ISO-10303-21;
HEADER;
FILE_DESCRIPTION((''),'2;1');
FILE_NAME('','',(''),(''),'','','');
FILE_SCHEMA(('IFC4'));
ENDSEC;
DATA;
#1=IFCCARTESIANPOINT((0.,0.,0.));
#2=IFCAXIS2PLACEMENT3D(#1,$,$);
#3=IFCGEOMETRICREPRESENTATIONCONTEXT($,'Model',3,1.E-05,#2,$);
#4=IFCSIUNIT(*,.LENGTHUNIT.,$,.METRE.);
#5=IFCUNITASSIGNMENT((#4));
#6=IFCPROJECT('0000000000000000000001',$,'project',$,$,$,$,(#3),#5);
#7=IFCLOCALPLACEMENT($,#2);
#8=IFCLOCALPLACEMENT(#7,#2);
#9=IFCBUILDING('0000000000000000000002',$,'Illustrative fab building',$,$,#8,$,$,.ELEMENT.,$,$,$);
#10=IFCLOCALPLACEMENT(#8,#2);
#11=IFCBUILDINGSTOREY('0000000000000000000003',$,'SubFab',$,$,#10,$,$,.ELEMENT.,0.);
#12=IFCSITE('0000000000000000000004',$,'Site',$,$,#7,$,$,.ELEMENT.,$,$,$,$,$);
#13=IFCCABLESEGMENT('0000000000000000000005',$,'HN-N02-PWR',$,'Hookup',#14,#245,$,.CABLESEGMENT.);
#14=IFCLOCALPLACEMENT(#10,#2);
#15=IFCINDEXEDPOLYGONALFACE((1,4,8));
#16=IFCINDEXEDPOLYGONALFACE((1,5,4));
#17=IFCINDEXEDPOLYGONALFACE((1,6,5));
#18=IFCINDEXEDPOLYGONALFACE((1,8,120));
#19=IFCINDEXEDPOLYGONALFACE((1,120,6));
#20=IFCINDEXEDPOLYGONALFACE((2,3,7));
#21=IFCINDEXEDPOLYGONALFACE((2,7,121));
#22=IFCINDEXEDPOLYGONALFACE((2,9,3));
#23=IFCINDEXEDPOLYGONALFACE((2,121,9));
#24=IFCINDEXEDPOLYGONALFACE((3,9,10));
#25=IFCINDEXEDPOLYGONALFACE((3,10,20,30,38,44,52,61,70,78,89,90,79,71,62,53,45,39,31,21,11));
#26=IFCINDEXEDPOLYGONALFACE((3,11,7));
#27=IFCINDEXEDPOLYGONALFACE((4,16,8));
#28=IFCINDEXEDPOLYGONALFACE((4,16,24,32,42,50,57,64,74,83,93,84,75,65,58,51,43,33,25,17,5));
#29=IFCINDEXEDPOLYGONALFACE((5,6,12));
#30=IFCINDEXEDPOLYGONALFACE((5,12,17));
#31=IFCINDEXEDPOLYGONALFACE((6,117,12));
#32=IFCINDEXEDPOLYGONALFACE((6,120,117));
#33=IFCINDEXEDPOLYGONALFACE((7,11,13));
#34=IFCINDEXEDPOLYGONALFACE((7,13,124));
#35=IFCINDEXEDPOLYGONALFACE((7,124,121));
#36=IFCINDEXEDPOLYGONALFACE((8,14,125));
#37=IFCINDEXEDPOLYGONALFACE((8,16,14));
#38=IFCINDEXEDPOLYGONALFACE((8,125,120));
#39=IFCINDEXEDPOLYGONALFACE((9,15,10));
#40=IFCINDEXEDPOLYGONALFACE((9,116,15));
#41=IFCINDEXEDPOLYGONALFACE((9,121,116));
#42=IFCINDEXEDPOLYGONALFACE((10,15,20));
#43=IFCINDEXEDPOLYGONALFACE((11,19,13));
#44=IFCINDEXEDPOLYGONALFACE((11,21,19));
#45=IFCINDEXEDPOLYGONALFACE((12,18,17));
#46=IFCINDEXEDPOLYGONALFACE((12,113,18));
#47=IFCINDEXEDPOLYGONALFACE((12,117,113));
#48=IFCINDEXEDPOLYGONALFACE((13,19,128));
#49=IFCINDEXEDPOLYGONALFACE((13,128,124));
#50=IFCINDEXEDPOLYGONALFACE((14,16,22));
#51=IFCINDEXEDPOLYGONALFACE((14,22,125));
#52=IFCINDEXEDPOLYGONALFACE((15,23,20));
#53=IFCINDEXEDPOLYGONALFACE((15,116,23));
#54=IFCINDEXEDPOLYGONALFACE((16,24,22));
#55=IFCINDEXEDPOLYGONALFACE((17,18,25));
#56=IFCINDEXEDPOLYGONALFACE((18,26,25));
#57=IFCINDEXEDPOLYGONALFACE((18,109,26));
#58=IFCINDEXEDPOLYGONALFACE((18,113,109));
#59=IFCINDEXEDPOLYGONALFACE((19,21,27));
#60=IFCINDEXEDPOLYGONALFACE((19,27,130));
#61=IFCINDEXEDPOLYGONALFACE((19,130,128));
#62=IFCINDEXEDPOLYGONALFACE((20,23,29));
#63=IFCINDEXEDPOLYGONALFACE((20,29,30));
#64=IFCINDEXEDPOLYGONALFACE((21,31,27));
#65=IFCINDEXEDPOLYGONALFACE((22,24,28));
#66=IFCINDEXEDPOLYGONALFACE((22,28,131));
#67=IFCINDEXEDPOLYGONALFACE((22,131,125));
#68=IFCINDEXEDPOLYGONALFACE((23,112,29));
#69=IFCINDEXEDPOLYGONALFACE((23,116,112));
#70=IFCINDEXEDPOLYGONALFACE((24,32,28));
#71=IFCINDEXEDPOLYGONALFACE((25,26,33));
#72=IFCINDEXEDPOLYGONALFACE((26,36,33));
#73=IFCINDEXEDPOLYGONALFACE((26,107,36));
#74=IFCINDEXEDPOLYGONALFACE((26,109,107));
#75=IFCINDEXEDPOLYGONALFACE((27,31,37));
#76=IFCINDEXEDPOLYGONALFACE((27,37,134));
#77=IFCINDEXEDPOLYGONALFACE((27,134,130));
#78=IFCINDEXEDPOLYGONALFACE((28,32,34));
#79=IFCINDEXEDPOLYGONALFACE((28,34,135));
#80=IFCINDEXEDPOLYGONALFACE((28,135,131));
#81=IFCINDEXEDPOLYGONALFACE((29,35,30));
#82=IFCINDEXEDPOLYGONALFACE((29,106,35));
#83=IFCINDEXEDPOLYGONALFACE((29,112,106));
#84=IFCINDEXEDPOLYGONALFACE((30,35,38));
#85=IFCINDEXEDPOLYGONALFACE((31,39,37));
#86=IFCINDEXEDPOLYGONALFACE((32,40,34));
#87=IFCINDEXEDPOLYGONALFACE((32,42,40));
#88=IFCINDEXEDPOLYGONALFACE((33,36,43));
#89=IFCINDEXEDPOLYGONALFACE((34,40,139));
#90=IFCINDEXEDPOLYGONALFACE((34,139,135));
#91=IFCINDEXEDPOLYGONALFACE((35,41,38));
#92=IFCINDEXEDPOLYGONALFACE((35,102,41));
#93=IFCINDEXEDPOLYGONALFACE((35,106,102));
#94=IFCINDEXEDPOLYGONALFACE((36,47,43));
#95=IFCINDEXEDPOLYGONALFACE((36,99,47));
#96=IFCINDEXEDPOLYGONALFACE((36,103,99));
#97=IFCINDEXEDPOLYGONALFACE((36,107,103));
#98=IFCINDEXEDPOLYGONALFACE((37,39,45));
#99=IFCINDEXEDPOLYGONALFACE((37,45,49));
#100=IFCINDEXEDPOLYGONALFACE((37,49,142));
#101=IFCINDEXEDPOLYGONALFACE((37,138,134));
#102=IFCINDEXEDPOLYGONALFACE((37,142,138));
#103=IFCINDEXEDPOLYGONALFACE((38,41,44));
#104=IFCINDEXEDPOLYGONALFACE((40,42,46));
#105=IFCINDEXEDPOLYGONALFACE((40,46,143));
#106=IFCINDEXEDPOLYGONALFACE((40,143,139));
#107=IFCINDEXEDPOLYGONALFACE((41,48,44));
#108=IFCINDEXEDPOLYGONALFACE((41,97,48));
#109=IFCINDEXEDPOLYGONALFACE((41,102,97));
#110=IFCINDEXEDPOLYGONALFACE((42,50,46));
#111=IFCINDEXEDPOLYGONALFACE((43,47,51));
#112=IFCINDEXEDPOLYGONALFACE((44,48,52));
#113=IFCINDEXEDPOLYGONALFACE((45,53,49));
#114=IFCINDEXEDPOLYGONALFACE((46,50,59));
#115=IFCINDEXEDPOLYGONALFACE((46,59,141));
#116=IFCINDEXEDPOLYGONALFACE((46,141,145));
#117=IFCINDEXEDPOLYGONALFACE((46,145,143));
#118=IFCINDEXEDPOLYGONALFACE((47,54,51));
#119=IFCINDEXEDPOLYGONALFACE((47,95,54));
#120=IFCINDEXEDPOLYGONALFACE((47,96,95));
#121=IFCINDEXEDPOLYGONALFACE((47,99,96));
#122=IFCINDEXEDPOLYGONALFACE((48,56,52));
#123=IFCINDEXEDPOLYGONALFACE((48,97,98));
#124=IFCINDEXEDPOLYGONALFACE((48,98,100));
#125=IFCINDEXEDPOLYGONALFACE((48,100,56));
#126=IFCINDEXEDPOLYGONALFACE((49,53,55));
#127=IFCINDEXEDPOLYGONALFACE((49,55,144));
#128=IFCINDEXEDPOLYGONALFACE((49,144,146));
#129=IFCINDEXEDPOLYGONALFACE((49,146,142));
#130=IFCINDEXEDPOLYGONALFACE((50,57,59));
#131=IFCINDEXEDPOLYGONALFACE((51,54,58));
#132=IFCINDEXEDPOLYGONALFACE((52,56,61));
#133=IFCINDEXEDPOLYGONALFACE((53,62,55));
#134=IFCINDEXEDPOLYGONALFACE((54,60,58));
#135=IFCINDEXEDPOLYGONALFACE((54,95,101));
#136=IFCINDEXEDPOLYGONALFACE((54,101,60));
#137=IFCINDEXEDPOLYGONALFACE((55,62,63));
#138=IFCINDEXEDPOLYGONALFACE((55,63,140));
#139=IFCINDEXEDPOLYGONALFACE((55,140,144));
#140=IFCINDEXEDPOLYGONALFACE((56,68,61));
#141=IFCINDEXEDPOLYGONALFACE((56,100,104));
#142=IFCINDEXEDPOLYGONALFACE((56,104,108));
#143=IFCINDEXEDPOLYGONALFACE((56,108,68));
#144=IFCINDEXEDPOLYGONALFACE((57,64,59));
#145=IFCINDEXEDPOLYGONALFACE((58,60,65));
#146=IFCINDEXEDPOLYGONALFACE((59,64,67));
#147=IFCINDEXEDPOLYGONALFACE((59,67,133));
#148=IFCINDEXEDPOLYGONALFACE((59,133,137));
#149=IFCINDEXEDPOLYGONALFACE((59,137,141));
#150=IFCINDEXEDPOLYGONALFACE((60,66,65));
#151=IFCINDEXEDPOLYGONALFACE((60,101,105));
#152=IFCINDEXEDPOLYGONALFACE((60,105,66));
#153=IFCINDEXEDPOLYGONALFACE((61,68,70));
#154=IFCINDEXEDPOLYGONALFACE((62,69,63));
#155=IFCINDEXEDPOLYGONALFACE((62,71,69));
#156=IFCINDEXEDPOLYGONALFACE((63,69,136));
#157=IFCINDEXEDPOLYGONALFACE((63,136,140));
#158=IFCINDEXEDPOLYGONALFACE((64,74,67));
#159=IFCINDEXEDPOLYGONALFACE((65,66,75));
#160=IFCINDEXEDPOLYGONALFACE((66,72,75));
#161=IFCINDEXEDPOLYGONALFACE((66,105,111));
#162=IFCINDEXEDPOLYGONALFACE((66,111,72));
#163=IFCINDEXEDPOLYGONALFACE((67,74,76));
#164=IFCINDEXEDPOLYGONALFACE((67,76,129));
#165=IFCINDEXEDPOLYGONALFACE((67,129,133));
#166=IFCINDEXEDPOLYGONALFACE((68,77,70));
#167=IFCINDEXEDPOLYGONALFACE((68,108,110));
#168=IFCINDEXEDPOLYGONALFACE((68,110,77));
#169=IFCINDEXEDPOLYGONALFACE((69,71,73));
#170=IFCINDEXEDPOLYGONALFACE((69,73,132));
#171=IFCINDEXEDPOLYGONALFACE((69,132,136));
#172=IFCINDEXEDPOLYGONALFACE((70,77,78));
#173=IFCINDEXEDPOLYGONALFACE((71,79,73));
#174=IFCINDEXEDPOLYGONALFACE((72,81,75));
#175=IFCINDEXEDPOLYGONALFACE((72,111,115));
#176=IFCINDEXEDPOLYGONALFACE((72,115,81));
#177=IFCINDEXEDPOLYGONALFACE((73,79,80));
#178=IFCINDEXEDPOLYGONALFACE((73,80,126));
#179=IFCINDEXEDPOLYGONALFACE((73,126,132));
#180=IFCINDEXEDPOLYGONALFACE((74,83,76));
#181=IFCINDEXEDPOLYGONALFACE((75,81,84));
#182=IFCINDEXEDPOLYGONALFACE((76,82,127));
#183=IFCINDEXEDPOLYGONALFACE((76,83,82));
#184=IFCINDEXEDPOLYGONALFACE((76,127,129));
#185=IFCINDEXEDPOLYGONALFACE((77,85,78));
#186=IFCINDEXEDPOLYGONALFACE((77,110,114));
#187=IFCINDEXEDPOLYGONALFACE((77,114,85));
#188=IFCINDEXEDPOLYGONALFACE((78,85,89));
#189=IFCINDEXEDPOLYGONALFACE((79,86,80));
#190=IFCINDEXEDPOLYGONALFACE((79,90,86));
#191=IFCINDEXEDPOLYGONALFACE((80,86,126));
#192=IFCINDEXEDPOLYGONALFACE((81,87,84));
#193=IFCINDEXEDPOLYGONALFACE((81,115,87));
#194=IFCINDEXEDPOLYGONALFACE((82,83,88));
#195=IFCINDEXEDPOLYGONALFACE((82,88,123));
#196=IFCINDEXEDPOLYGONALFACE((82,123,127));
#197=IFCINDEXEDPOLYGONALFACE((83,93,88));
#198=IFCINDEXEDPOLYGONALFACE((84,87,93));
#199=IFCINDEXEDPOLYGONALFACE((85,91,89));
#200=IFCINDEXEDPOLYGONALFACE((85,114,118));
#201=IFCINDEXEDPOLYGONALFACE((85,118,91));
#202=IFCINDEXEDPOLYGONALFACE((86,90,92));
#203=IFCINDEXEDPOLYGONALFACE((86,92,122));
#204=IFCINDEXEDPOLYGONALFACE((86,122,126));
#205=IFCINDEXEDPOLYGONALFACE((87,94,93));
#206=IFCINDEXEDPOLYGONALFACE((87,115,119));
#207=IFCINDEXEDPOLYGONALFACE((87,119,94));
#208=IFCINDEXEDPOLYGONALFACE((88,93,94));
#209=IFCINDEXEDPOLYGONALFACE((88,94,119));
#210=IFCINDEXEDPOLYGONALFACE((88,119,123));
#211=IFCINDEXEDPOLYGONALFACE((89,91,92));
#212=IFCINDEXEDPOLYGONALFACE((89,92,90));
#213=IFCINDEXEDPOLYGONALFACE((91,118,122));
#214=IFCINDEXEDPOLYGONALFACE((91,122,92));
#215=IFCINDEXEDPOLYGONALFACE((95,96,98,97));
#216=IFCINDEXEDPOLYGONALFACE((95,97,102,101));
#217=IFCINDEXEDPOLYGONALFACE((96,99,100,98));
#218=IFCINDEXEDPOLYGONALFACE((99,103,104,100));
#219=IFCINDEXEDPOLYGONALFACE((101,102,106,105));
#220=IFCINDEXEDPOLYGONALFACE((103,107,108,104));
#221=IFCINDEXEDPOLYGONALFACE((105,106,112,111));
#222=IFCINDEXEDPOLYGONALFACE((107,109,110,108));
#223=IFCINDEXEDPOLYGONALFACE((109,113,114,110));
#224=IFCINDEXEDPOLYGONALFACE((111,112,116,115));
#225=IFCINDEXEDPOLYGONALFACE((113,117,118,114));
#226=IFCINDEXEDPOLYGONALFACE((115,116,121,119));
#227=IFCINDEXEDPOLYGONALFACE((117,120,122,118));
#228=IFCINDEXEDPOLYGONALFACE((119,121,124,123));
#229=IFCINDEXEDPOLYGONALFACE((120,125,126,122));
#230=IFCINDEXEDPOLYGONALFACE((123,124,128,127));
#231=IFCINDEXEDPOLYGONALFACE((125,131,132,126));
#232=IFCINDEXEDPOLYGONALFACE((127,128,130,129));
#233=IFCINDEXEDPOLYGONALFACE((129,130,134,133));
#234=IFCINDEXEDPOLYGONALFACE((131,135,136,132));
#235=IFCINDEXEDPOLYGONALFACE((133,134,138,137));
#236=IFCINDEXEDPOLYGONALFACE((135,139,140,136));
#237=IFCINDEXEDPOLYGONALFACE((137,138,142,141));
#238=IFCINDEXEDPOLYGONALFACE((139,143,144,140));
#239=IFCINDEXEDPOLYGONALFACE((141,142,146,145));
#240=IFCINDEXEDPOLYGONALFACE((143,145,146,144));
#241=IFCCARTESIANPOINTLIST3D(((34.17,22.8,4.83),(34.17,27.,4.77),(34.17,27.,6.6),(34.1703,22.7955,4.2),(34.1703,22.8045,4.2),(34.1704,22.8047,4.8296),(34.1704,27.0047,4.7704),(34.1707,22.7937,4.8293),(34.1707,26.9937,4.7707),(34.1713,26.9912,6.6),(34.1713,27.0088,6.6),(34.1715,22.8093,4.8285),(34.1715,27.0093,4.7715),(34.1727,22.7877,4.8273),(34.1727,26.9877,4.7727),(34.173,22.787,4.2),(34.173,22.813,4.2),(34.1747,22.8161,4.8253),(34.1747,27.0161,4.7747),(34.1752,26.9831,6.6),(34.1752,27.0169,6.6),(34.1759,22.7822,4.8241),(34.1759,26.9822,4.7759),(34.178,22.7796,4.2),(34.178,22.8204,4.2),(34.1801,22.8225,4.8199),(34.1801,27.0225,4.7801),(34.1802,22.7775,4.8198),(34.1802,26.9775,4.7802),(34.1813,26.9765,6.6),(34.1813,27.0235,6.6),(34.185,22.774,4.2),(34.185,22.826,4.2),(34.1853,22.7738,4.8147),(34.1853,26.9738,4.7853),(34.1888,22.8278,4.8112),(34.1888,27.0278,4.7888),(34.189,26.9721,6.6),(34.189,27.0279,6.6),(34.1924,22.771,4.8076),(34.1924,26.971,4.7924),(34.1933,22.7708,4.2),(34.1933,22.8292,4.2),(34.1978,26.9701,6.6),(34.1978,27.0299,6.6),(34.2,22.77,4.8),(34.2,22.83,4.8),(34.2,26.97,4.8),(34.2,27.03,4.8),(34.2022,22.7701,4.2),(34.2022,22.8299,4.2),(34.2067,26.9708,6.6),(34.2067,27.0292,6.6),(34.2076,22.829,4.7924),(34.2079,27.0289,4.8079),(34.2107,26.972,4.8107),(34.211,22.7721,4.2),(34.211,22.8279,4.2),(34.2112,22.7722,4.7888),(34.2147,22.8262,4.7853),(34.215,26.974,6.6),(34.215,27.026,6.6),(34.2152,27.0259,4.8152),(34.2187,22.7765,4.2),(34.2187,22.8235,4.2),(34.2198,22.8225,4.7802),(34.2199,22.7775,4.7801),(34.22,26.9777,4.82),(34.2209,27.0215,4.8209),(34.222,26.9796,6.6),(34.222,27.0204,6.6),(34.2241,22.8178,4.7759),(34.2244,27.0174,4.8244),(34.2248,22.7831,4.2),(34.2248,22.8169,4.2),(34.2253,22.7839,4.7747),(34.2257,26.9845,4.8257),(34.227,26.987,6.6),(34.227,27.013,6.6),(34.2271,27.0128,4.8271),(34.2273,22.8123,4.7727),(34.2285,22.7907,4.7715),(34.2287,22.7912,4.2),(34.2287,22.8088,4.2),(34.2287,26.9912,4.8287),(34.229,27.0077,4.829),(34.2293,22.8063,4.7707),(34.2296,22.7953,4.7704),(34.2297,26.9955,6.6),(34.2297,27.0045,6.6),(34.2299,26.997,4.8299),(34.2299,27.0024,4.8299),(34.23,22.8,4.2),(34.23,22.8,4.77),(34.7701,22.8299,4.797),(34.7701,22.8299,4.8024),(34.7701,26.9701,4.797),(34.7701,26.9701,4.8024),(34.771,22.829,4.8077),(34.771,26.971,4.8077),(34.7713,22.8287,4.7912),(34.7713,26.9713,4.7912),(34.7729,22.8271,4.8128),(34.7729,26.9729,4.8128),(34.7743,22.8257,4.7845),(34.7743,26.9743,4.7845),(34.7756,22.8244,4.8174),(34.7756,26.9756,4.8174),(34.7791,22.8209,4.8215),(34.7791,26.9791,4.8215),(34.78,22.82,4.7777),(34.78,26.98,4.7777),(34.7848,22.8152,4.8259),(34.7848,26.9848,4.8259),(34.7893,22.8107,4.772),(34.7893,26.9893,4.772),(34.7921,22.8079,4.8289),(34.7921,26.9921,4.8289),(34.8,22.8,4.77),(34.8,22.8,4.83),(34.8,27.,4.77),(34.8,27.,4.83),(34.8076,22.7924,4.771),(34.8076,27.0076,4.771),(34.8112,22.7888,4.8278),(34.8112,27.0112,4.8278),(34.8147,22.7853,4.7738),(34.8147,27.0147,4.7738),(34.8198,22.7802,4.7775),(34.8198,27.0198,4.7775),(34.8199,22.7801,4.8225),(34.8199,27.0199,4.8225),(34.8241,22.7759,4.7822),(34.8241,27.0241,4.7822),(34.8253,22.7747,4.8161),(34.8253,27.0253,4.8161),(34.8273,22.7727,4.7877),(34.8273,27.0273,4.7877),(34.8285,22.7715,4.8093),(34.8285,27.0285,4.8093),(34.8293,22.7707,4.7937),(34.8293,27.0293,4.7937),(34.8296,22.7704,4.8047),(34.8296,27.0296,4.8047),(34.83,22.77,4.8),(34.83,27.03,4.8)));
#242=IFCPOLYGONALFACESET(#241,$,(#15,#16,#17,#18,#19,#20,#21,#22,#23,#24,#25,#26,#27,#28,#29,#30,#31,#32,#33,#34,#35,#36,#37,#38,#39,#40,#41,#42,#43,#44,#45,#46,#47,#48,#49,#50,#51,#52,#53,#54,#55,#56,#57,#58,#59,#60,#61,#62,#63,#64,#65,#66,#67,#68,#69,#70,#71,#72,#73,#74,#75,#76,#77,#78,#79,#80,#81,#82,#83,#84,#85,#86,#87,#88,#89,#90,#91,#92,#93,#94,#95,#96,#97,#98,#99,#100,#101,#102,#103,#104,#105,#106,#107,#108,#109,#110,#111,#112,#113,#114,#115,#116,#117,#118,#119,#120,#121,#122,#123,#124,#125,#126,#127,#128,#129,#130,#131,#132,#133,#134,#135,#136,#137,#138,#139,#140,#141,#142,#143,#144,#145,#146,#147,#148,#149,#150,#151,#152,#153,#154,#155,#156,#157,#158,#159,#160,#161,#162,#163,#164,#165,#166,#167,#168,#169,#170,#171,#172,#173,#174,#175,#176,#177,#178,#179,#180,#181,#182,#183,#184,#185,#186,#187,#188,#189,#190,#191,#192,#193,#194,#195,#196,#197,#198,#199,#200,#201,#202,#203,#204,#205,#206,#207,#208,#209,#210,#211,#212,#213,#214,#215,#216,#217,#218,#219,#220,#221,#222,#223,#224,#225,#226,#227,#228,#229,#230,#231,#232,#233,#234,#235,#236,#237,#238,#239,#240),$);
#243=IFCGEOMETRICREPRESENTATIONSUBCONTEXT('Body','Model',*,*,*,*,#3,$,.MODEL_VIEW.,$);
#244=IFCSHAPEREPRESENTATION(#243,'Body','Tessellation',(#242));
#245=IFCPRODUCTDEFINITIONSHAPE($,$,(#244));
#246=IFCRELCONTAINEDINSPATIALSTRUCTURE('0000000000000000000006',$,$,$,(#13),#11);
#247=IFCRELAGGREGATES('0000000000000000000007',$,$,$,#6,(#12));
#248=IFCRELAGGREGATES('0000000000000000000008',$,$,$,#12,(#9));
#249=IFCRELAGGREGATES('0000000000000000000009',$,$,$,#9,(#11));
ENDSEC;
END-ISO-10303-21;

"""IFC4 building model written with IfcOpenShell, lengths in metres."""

from ifc_helpers import new_model, entity, si_unit, origin, place, context, subcontext, project, spatial, element, save


model = new_model("IFC4")

# Units and contexts
model_context = context("Model", 3, precision=1e-05, world=origin())
body_context = subcontext(model_context, "Body", "Model", "MODEL_VIEW")
ifc_project = project(units=[si_unit("LENGTHUNIT", "METRE")], contexts=[model_context])

# Site, building, storey
site_placement = place(None, origin())
site = spatial("IfcSite", under=ifc_project, at=site_placement, Name="Site", CompositionType="ELEMENT")
building_placement = place(site_placement, origin())
building = spatial("IfcBuilding", under=site, at=building_placement, Name="Illustrative fab building", CompositionType="ELEMENT")
storey_placement = place(building_placement, origin())
storey = spatial("IfcBuildingStorey", under=building, at=storey_placement, Name="SubFab", CompositionType="ELEMENT", Elevation=0.0)

# Cable segment
cable_segment_1_placement = place(storey_placement, origin())
element("IfcCableSegment", 1, at=cable_segment_1_placement, inside=storey, Name="HN-N02-PWR", ObjectType="Hookup", PredefinedType="CABLESEGMENT", context=body_context, shape_type="AdvancedSweptSolid", body=[
    entity("IfcSweptDiskSolid", entity("IfcPolyline", [entity("IfcCartesianPoint", [34.2, 22.8, 4.2]), entity("IfcCartesianPoint", [34.2, 22.8, 4.8]), entity("IfcCartesianPoint", [34.8, 22.8, 4.8]), entity("IfcCartesianPoint", [34.8, 27.0, 4.8]), entity("IfcCartesianPoint", [34.2, 27.0, 4.8]), entity("IfcCartesianPoint", [34.2, 27.0, 6.6])]), 0.03),
])

save(model, "model.ifc")
